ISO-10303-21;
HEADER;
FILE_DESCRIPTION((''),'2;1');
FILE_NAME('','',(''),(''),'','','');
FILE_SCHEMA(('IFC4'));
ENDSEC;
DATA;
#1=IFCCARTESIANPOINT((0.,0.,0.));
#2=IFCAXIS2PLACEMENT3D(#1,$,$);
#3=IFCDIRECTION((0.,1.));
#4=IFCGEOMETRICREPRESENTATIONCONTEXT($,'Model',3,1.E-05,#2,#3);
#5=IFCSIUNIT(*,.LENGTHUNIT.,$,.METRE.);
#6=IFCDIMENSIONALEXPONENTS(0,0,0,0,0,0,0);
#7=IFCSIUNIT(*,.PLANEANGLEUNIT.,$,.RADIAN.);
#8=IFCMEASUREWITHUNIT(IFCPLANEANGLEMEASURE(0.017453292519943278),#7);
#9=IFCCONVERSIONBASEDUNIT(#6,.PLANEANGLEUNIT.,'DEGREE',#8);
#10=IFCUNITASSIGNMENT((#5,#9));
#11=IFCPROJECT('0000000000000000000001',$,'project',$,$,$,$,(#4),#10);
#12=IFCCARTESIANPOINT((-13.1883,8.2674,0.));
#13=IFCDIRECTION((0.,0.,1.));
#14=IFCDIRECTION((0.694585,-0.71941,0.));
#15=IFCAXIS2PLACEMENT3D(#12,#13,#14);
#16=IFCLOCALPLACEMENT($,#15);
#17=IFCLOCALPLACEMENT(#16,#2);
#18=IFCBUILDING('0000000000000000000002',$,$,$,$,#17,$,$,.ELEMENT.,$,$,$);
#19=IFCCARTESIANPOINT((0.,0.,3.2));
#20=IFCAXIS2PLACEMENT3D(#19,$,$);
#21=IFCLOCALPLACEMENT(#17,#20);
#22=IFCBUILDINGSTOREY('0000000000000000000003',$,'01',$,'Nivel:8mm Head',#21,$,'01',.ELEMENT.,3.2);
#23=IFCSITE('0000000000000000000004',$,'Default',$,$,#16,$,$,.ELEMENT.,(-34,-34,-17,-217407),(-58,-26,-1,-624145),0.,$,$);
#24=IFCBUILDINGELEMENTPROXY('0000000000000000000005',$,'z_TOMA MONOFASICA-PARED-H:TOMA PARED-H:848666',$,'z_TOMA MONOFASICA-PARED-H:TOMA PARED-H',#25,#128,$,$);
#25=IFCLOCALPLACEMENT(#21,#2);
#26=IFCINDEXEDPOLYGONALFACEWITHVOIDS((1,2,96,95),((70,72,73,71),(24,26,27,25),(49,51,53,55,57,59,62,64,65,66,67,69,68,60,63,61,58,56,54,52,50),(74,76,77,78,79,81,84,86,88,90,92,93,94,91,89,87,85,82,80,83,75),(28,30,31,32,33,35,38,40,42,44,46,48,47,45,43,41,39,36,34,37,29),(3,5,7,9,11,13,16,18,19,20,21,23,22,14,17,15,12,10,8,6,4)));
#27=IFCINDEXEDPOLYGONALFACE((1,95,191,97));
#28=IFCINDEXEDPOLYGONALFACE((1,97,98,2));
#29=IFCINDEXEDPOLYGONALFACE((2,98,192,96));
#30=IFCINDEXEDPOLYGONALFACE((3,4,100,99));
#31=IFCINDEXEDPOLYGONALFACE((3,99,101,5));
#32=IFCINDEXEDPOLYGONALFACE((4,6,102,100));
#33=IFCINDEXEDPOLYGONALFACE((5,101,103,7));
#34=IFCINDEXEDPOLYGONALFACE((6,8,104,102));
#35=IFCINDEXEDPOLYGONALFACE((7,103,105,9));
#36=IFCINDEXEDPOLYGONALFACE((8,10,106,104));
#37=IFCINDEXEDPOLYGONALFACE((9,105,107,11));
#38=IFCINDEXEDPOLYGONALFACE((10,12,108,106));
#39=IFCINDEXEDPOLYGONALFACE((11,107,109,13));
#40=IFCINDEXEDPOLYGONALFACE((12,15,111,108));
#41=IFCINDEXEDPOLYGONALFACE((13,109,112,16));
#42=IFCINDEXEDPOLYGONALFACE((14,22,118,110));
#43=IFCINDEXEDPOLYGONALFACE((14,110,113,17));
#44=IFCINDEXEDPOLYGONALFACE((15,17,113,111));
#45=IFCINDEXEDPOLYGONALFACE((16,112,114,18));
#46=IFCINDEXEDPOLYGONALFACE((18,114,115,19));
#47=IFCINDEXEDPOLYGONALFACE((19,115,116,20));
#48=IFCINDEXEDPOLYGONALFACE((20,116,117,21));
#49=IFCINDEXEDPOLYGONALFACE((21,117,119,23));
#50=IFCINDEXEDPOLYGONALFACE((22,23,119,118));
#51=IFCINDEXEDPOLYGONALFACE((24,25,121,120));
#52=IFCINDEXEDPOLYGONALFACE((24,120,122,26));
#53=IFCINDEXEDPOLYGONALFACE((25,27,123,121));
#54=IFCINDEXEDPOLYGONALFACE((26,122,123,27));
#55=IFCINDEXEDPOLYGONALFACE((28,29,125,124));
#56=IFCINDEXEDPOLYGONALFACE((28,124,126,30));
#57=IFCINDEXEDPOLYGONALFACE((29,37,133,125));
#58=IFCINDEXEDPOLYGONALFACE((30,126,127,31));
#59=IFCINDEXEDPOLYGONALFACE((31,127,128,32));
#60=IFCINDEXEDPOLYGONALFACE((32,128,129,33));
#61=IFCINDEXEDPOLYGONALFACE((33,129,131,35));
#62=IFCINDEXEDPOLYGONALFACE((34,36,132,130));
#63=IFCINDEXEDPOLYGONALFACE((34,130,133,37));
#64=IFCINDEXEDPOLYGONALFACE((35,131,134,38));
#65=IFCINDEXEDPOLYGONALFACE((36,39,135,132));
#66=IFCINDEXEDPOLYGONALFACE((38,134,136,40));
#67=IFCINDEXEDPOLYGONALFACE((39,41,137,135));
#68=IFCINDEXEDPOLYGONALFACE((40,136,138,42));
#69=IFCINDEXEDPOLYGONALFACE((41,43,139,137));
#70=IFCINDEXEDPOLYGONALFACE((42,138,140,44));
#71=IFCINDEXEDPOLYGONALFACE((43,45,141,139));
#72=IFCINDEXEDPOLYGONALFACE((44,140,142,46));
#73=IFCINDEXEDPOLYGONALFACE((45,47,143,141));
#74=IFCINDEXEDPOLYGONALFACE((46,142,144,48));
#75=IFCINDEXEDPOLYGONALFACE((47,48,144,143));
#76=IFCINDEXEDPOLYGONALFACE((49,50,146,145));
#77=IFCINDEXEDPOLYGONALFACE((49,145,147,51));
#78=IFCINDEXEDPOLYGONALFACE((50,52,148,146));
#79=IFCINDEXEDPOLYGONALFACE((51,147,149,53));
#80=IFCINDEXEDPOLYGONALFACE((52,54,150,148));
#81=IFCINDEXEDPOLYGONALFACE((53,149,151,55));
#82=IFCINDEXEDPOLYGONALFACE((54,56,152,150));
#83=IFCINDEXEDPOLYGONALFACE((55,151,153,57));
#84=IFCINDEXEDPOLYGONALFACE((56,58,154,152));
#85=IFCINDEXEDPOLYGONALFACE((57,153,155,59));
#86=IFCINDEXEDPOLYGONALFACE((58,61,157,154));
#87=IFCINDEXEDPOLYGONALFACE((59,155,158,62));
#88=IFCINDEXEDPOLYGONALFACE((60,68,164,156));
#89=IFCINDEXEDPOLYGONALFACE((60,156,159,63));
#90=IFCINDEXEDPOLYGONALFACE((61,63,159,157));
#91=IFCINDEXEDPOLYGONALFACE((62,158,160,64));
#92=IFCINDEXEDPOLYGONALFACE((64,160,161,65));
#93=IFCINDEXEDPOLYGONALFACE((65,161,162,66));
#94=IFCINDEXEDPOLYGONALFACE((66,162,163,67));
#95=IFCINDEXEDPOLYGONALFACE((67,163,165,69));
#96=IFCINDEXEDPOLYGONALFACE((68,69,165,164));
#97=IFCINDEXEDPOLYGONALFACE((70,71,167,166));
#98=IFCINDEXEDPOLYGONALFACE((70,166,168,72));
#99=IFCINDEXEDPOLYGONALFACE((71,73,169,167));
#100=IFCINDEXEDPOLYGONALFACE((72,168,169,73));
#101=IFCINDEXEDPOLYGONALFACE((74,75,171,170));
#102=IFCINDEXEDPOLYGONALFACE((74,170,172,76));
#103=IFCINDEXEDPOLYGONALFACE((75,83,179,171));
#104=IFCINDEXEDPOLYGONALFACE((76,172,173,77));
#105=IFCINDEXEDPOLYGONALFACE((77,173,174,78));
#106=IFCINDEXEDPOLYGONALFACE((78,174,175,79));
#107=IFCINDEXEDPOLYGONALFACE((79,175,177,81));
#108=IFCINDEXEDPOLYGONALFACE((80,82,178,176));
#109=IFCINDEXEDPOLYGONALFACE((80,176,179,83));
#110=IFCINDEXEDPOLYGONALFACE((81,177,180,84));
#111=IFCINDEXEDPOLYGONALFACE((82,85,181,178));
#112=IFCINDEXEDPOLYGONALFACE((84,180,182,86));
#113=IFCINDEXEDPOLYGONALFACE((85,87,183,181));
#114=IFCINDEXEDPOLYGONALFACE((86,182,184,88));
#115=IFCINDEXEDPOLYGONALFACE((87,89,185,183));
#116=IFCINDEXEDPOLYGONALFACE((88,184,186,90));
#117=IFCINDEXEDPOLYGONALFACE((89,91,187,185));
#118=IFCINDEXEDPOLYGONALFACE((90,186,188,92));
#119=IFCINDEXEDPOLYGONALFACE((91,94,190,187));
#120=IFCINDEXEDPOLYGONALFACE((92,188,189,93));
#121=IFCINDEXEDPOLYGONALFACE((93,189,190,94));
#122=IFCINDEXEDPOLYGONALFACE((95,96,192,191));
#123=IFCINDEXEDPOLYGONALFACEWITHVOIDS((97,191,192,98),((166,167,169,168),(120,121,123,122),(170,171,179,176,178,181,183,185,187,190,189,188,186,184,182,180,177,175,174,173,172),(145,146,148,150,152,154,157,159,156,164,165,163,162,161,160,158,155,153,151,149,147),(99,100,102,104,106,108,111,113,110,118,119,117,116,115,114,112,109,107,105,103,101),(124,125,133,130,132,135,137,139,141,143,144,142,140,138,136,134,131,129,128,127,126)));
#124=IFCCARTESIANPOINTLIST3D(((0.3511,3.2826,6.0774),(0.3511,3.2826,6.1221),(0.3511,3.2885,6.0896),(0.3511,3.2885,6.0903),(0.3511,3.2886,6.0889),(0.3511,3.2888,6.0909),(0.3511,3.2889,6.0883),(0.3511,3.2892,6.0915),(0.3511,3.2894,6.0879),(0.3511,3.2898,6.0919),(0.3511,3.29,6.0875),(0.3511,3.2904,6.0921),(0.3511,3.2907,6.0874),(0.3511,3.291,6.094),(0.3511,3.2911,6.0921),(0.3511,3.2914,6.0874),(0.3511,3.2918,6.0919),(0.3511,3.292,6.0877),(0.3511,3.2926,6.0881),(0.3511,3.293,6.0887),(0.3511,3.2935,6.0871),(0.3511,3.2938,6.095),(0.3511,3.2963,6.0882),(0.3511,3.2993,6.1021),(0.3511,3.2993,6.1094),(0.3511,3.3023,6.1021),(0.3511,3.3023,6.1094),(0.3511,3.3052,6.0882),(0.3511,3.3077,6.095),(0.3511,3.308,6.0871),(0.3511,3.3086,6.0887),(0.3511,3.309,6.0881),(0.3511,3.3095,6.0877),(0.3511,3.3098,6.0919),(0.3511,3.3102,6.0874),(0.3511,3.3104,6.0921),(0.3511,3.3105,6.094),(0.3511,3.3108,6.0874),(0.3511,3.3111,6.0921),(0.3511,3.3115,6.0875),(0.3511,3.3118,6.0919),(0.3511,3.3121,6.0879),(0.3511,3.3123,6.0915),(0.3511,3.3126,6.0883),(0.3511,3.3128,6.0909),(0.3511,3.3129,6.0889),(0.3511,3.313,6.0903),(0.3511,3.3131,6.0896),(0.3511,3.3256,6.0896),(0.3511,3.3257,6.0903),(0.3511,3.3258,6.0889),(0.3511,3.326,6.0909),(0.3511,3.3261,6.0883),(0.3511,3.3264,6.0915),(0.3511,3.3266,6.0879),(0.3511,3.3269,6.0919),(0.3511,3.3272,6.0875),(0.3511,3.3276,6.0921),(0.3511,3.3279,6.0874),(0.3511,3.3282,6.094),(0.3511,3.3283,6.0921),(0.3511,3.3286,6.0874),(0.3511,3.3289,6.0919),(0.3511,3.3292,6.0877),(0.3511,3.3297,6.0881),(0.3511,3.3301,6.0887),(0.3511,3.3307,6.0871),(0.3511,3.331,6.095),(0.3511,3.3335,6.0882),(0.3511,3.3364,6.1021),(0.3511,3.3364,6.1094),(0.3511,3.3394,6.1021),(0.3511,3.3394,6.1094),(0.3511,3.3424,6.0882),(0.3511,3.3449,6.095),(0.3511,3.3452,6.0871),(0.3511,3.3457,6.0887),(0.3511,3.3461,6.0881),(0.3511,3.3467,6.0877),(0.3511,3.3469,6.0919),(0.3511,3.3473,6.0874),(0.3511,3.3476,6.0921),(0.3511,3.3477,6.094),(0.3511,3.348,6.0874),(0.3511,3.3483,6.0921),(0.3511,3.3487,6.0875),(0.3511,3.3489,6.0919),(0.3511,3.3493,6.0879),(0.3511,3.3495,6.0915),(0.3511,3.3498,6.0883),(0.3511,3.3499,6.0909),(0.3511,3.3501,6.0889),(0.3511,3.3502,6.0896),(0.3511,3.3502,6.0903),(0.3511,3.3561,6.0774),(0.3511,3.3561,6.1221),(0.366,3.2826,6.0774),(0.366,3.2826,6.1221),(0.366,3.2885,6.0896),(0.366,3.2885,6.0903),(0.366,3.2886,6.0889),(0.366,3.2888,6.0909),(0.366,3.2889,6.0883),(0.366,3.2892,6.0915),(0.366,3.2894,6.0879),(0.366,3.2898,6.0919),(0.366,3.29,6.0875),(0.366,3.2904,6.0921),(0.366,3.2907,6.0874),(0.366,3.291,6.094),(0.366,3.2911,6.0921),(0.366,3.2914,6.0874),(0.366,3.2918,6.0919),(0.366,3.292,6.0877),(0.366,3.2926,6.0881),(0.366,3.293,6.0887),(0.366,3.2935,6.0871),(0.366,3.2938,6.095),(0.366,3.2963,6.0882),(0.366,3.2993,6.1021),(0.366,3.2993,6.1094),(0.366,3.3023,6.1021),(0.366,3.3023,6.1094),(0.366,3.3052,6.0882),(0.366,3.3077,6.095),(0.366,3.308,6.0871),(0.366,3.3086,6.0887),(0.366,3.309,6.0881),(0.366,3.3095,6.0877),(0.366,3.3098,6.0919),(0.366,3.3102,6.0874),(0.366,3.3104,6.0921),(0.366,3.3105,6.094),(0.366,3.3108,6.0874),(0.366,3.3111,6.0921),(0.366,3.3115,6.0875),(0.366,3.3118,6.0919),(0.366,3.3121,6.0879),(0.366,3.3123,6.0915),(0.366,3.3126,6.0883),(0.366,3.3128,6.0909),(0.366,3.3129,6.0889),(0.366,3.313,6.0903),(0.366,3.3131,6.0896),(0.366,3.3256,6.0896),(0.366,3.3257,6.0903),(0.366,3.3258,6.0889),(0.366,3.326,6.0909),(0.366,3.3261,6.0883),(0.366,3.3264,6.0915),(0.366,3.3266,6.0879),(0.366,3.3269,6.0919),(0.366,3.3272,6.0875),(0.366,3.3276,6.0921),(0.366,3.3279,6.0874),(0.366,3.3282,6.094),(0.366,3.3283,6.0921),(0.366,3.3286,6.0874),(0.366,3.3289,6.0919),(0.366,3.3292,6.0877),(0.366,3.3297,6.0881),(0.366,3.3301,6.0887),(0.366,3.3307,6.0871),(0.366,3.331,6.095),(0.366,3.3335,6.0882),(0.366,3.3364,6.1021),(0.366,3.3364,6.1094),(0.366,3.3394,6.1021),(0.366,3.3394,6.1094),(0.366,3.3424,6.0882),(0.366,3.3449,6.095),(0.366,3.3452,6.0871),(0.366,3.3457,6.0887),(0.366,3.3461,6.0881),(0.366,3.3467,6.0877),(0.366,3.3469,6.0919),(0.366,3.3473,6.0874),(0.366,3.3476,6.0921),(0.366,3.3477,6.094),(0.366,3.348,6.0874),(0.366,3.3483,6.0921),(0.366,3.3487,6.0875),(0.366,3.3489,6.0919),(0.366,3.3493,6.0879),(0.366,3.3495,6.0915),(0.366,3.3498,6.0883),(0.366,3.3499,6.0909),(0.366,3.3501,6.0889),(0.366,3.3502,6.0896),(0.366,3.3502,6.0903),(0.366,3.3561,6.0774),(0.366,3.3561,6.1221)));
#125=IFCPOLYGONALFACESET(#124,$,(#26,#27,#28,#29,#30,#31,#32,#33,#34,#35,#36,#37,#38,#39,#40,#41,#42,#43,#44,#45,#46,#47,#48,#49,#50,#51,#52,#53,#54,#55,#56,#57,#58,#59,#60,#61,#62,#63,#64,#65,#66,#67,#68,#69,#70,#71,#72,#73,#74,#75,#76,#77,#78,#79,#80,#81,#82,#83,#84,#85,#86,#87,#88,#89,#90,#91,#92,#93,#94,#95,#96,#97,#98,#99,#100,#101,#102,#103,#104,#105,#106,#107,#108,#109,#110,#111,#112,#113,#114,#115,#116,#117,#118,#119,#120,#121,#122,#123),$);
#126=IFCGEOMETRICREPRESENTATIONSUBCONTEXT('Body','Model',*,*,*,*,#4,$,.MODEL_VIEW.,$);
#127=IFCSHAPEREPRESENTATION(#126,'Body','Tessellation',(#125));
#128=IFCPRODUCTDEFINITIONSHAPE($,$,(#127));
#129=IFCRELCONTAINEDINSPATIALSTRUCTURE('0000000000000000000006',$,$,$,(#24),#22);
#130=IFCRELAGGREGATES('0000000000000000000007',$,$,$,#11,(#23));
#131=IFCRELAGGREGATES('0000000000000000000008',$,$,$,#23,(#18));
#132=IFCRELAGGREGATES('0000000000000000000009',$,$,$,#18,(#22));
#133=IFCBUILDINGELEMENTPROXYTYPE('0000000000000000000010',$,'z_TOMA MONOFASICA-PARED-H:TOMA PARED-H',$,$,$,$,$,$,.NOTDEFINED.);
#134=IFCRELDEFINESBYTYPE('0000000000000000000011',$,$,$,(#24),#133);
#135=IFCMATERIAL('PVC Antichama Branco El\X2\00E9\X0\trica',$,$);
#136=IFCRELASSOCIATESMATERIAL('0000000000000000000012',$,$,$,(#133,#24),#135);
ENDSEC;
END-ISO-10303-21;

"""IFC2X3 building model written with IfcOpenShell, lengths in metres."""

from ifc_helpers import new_model, entity, si_unit, converted_unit, direction, frame, frame_2d, origin, place, context, subcontext, project, spatial, polyline, circle_curve, parameter, trimmed, segment, composite_curve, outline, extrude, source, transform, mapped, material, type_object, type_shapes, element, save


model = new_model("IFC2X3")

# Units and contexts
model_context = context("Model", 3, precision=1e-05, world=origin(), true_north=direction((0.0, 1.0)))
body_context = subcontext(model_context, "Body", "Model", "MODEL_VIEW")
ifc_project = project(units=[si_unit("LENGTHUNIT", "METRE"), converted_unit("PLANEANGLEUNIT", "DEGREE", entity("IfcPlaneAngleMeasure", 0.017453292519943278), si_unit("PLANEANGLEUNIT", "RADIAN"), dimensions=[0, 0, 0, 0, 0, 0, 0])], contexts=[model_context])

# Site, building, storey
site_placement = place(None, frame((-13.1883, 8.2674, 0.0), z_axis=(0.0, 0.0, 1.0), x_axis=(0.694585, -0.71941, 0.0)))
site = spatial("IfcSite", under=ifc_project, at=site_placement, Name="Default", CompositionType="ELEMENT", RefLatitude=(-34, -34, -17, -217407), RefLongitude=(-58, -26, -1, -624145), RefElevation=0.0)
building_placement = place(site_placement, origin())
building = spatial("IfcBuilding", under=site, at=building_placement, CompositionType="ELEMENT")
storey_placement = place(building_placement, frame((0.0, 0.0, 3.2)))
storey = spatial("IfcBuildingStorey", under=building, at=storey_placement, Name="01", ObjectType="Nivel:8mm Head", LongName="01", CompositionType="ELEMENT", Elevation=3.2)

# Building element proxy
ifc_material_1 = material(Name="PVC Antichama Branco Elétrica")
building_element_proxy_type_1 = type_object("IfcBuildingElementProxyType", Name="z_TOMA MONOFASICA-PARED-H:TOMA PARED-H", PredefinedType="NOTDEFINED", material=ifc_material_1)
shared_shape_1 = source(origin(), body_context, "Body", "SweptSolid", [
    extrude(outline(polyline([(-0.0368, -0.0223), (0.0368, -0.0223), (0.0368, 0.0223), (-0.0368, 0.0223), (-0.0368, -0.0223)]), holes=[composite_curve([segment(polyline([(0.0141, 0.0115), (0.0116, 0.0047)]), True, "CONTINUOUS"), segment(polyline([(0.0116, 0.0047), (0.0088, 0.0057)]), True, "CONTINUOUS"), segment(polyline([(0.0088, 0.0057), (0.0096, 0.0078)]), True, "CONTINUOUS"), segment(trimmed(circle_curve(frame_2d((0.0087, 0.0099), x_axis=(1.0, 0.0)), 0.0024), [parameter(27.118901)], [parameter(292.881099)], True, "PARAMETER"), False, "CONTINUOUS"), segment(polyline([(0.0108, 0.011), (0.0113, 0.0126)]), True, "CONTINUOUS"), segment(polyline([(0.0113, 0.0126), (0.0141, 0.0115)]), True, "CONTINUOUS")], self_intersect=False), composite_curve([segment(polyline([(0.0255, 0.0047), (0.023, 0.0115)]), True, "CONTINUOUS"), segment(polyline([(0.023, 0.0115), (0.0258, 0.0126)]), True, "CONTINUOUS"), segment(polyline([(0.0258, 0.0126), (0.0264, 0.011)]), True, "CONTINUOUS"), segment(trimmed(circle_curve(frame_2d((0.0285, 0.0099), x_axis=(1.0, 0.0)), 0.0024), [parameter(247.118901)], [parameter(152.881099)], True, "PARAMETER"), False, "CONTINUOUS"), segment(polyline([(0.0276, 0.0078), (0.0283, 0.0057)]), True, "CONTINUOUS"), segment(polyline([(0.0283, 0.0057), (0.0255, 0.0047)]), True, "CONTINUOUS")], self_intersect=False), polyline([(0.0201, -0.0024), (0.0201, -0.0097), (0.0171, -0.0097), (0.0171, -0.0024), (0.0201, -0.0024)]), composite_curve([segment(polyline([(-0.0141, 0.0115), (-0.0113, 0.0126)]), True, "CONTINUOUS"), segment(polyline([(-0.0113, 0.0126), (-0.0108, 0.011)]), True, "CONTINUOUS"), segment(trimmed(circle_curve(frame_2d((-0.0087, 0.0099), x_axis=(1.0, 0.0)), 0.0024), [parameter(247.118901)], [parameter(152.881099)], True, "PARAMETER"), False, "CONTINUOUS"), segment(polyline([(-0.0096, 0.0078), (-0.0088, 0.0057)]), True, "CONTINUOUS"), segment(polyline([(-0.0088, 0.0057), (-0.0116, 0.0047)]), True, "CONTINUOUS"), segment(polyline([(-0.0116, 0.0047), (-0.0141, 0.0115)]), True, "CONTINUOUS")], self_intersect=False), composite_curve([segment(polyline([(-0.0255, 0.0047), (-0.0283, 0.0057)]), True, "CONTINUOUS"), segment(polyline([(-0.0283, 0.0057), (-0.0276, 0.0078)]), True, "CONTINUOUS"), segment(trimmed(circle_curve(frame_2d((-0.0285, 0.0099), x_axis=(1.0, 0.0)), 0.0024), [parameter(27.118901)], [parameter(292.881099)], True, "PARAMETER"), False, "CONTINUOUS"), segment(polyline([(-0.0264, 0.011), (-0.0258, 0.0126)]), True, "CONTINUOUS"), segment(polyline([(-0.0258, 0.0126), (-0.023, 0.0115)]), True, "CONTINUOUS"), segment(polyline([(-0.023, 0.0115), (-0.0255, 0.0047)]), True, "CONTINUOUS")], self_intersect=False), polyline([(-0.0201, -0.0024), (-0.0171, -0.0024), (-0.0171, -0.0097), (-0.0201, -0.0097), (-0.0201, -0.0024)])]), frame((0.0, -0.005, 0.0223), z_axis=(0.0, 1.0, 0.0), x_axis=(1.0, 0.0, 0.0)), (0.0, 0.0, 1.0), 0.0148),
])
type_shapes(building_element_proxy_type_1, [shared_shape_1])
for number, where, z_axis, x_axis, name in (
    (1, (0.361, 3.3194, 6.0774), (0.0, 0.0, 1.0), (0.0, 1.0, 0.0), "z_TOMA MONOFASICA-PARED-H:TOMA PARED-H:848666"),
):
    element("IfcBuildingElementProxy", number, at=place(storey_placement, frame(where, z_axis=z_axis, x_axis=x_axis)), inside=storey, type_object=building_element_proxy_type_1, material=ifc_material_1, Name=name, ObjectType="z_TOMA MONOFASICA-PARED-H:TOMA PARED-H", context=body_context, shape_type="MappedRepresentation", body=[
        mapped(shared_shape_1, transform((0.0, 0.0, 0.0), scale=1.0)),
    ])

save(model, "model.ifc")
